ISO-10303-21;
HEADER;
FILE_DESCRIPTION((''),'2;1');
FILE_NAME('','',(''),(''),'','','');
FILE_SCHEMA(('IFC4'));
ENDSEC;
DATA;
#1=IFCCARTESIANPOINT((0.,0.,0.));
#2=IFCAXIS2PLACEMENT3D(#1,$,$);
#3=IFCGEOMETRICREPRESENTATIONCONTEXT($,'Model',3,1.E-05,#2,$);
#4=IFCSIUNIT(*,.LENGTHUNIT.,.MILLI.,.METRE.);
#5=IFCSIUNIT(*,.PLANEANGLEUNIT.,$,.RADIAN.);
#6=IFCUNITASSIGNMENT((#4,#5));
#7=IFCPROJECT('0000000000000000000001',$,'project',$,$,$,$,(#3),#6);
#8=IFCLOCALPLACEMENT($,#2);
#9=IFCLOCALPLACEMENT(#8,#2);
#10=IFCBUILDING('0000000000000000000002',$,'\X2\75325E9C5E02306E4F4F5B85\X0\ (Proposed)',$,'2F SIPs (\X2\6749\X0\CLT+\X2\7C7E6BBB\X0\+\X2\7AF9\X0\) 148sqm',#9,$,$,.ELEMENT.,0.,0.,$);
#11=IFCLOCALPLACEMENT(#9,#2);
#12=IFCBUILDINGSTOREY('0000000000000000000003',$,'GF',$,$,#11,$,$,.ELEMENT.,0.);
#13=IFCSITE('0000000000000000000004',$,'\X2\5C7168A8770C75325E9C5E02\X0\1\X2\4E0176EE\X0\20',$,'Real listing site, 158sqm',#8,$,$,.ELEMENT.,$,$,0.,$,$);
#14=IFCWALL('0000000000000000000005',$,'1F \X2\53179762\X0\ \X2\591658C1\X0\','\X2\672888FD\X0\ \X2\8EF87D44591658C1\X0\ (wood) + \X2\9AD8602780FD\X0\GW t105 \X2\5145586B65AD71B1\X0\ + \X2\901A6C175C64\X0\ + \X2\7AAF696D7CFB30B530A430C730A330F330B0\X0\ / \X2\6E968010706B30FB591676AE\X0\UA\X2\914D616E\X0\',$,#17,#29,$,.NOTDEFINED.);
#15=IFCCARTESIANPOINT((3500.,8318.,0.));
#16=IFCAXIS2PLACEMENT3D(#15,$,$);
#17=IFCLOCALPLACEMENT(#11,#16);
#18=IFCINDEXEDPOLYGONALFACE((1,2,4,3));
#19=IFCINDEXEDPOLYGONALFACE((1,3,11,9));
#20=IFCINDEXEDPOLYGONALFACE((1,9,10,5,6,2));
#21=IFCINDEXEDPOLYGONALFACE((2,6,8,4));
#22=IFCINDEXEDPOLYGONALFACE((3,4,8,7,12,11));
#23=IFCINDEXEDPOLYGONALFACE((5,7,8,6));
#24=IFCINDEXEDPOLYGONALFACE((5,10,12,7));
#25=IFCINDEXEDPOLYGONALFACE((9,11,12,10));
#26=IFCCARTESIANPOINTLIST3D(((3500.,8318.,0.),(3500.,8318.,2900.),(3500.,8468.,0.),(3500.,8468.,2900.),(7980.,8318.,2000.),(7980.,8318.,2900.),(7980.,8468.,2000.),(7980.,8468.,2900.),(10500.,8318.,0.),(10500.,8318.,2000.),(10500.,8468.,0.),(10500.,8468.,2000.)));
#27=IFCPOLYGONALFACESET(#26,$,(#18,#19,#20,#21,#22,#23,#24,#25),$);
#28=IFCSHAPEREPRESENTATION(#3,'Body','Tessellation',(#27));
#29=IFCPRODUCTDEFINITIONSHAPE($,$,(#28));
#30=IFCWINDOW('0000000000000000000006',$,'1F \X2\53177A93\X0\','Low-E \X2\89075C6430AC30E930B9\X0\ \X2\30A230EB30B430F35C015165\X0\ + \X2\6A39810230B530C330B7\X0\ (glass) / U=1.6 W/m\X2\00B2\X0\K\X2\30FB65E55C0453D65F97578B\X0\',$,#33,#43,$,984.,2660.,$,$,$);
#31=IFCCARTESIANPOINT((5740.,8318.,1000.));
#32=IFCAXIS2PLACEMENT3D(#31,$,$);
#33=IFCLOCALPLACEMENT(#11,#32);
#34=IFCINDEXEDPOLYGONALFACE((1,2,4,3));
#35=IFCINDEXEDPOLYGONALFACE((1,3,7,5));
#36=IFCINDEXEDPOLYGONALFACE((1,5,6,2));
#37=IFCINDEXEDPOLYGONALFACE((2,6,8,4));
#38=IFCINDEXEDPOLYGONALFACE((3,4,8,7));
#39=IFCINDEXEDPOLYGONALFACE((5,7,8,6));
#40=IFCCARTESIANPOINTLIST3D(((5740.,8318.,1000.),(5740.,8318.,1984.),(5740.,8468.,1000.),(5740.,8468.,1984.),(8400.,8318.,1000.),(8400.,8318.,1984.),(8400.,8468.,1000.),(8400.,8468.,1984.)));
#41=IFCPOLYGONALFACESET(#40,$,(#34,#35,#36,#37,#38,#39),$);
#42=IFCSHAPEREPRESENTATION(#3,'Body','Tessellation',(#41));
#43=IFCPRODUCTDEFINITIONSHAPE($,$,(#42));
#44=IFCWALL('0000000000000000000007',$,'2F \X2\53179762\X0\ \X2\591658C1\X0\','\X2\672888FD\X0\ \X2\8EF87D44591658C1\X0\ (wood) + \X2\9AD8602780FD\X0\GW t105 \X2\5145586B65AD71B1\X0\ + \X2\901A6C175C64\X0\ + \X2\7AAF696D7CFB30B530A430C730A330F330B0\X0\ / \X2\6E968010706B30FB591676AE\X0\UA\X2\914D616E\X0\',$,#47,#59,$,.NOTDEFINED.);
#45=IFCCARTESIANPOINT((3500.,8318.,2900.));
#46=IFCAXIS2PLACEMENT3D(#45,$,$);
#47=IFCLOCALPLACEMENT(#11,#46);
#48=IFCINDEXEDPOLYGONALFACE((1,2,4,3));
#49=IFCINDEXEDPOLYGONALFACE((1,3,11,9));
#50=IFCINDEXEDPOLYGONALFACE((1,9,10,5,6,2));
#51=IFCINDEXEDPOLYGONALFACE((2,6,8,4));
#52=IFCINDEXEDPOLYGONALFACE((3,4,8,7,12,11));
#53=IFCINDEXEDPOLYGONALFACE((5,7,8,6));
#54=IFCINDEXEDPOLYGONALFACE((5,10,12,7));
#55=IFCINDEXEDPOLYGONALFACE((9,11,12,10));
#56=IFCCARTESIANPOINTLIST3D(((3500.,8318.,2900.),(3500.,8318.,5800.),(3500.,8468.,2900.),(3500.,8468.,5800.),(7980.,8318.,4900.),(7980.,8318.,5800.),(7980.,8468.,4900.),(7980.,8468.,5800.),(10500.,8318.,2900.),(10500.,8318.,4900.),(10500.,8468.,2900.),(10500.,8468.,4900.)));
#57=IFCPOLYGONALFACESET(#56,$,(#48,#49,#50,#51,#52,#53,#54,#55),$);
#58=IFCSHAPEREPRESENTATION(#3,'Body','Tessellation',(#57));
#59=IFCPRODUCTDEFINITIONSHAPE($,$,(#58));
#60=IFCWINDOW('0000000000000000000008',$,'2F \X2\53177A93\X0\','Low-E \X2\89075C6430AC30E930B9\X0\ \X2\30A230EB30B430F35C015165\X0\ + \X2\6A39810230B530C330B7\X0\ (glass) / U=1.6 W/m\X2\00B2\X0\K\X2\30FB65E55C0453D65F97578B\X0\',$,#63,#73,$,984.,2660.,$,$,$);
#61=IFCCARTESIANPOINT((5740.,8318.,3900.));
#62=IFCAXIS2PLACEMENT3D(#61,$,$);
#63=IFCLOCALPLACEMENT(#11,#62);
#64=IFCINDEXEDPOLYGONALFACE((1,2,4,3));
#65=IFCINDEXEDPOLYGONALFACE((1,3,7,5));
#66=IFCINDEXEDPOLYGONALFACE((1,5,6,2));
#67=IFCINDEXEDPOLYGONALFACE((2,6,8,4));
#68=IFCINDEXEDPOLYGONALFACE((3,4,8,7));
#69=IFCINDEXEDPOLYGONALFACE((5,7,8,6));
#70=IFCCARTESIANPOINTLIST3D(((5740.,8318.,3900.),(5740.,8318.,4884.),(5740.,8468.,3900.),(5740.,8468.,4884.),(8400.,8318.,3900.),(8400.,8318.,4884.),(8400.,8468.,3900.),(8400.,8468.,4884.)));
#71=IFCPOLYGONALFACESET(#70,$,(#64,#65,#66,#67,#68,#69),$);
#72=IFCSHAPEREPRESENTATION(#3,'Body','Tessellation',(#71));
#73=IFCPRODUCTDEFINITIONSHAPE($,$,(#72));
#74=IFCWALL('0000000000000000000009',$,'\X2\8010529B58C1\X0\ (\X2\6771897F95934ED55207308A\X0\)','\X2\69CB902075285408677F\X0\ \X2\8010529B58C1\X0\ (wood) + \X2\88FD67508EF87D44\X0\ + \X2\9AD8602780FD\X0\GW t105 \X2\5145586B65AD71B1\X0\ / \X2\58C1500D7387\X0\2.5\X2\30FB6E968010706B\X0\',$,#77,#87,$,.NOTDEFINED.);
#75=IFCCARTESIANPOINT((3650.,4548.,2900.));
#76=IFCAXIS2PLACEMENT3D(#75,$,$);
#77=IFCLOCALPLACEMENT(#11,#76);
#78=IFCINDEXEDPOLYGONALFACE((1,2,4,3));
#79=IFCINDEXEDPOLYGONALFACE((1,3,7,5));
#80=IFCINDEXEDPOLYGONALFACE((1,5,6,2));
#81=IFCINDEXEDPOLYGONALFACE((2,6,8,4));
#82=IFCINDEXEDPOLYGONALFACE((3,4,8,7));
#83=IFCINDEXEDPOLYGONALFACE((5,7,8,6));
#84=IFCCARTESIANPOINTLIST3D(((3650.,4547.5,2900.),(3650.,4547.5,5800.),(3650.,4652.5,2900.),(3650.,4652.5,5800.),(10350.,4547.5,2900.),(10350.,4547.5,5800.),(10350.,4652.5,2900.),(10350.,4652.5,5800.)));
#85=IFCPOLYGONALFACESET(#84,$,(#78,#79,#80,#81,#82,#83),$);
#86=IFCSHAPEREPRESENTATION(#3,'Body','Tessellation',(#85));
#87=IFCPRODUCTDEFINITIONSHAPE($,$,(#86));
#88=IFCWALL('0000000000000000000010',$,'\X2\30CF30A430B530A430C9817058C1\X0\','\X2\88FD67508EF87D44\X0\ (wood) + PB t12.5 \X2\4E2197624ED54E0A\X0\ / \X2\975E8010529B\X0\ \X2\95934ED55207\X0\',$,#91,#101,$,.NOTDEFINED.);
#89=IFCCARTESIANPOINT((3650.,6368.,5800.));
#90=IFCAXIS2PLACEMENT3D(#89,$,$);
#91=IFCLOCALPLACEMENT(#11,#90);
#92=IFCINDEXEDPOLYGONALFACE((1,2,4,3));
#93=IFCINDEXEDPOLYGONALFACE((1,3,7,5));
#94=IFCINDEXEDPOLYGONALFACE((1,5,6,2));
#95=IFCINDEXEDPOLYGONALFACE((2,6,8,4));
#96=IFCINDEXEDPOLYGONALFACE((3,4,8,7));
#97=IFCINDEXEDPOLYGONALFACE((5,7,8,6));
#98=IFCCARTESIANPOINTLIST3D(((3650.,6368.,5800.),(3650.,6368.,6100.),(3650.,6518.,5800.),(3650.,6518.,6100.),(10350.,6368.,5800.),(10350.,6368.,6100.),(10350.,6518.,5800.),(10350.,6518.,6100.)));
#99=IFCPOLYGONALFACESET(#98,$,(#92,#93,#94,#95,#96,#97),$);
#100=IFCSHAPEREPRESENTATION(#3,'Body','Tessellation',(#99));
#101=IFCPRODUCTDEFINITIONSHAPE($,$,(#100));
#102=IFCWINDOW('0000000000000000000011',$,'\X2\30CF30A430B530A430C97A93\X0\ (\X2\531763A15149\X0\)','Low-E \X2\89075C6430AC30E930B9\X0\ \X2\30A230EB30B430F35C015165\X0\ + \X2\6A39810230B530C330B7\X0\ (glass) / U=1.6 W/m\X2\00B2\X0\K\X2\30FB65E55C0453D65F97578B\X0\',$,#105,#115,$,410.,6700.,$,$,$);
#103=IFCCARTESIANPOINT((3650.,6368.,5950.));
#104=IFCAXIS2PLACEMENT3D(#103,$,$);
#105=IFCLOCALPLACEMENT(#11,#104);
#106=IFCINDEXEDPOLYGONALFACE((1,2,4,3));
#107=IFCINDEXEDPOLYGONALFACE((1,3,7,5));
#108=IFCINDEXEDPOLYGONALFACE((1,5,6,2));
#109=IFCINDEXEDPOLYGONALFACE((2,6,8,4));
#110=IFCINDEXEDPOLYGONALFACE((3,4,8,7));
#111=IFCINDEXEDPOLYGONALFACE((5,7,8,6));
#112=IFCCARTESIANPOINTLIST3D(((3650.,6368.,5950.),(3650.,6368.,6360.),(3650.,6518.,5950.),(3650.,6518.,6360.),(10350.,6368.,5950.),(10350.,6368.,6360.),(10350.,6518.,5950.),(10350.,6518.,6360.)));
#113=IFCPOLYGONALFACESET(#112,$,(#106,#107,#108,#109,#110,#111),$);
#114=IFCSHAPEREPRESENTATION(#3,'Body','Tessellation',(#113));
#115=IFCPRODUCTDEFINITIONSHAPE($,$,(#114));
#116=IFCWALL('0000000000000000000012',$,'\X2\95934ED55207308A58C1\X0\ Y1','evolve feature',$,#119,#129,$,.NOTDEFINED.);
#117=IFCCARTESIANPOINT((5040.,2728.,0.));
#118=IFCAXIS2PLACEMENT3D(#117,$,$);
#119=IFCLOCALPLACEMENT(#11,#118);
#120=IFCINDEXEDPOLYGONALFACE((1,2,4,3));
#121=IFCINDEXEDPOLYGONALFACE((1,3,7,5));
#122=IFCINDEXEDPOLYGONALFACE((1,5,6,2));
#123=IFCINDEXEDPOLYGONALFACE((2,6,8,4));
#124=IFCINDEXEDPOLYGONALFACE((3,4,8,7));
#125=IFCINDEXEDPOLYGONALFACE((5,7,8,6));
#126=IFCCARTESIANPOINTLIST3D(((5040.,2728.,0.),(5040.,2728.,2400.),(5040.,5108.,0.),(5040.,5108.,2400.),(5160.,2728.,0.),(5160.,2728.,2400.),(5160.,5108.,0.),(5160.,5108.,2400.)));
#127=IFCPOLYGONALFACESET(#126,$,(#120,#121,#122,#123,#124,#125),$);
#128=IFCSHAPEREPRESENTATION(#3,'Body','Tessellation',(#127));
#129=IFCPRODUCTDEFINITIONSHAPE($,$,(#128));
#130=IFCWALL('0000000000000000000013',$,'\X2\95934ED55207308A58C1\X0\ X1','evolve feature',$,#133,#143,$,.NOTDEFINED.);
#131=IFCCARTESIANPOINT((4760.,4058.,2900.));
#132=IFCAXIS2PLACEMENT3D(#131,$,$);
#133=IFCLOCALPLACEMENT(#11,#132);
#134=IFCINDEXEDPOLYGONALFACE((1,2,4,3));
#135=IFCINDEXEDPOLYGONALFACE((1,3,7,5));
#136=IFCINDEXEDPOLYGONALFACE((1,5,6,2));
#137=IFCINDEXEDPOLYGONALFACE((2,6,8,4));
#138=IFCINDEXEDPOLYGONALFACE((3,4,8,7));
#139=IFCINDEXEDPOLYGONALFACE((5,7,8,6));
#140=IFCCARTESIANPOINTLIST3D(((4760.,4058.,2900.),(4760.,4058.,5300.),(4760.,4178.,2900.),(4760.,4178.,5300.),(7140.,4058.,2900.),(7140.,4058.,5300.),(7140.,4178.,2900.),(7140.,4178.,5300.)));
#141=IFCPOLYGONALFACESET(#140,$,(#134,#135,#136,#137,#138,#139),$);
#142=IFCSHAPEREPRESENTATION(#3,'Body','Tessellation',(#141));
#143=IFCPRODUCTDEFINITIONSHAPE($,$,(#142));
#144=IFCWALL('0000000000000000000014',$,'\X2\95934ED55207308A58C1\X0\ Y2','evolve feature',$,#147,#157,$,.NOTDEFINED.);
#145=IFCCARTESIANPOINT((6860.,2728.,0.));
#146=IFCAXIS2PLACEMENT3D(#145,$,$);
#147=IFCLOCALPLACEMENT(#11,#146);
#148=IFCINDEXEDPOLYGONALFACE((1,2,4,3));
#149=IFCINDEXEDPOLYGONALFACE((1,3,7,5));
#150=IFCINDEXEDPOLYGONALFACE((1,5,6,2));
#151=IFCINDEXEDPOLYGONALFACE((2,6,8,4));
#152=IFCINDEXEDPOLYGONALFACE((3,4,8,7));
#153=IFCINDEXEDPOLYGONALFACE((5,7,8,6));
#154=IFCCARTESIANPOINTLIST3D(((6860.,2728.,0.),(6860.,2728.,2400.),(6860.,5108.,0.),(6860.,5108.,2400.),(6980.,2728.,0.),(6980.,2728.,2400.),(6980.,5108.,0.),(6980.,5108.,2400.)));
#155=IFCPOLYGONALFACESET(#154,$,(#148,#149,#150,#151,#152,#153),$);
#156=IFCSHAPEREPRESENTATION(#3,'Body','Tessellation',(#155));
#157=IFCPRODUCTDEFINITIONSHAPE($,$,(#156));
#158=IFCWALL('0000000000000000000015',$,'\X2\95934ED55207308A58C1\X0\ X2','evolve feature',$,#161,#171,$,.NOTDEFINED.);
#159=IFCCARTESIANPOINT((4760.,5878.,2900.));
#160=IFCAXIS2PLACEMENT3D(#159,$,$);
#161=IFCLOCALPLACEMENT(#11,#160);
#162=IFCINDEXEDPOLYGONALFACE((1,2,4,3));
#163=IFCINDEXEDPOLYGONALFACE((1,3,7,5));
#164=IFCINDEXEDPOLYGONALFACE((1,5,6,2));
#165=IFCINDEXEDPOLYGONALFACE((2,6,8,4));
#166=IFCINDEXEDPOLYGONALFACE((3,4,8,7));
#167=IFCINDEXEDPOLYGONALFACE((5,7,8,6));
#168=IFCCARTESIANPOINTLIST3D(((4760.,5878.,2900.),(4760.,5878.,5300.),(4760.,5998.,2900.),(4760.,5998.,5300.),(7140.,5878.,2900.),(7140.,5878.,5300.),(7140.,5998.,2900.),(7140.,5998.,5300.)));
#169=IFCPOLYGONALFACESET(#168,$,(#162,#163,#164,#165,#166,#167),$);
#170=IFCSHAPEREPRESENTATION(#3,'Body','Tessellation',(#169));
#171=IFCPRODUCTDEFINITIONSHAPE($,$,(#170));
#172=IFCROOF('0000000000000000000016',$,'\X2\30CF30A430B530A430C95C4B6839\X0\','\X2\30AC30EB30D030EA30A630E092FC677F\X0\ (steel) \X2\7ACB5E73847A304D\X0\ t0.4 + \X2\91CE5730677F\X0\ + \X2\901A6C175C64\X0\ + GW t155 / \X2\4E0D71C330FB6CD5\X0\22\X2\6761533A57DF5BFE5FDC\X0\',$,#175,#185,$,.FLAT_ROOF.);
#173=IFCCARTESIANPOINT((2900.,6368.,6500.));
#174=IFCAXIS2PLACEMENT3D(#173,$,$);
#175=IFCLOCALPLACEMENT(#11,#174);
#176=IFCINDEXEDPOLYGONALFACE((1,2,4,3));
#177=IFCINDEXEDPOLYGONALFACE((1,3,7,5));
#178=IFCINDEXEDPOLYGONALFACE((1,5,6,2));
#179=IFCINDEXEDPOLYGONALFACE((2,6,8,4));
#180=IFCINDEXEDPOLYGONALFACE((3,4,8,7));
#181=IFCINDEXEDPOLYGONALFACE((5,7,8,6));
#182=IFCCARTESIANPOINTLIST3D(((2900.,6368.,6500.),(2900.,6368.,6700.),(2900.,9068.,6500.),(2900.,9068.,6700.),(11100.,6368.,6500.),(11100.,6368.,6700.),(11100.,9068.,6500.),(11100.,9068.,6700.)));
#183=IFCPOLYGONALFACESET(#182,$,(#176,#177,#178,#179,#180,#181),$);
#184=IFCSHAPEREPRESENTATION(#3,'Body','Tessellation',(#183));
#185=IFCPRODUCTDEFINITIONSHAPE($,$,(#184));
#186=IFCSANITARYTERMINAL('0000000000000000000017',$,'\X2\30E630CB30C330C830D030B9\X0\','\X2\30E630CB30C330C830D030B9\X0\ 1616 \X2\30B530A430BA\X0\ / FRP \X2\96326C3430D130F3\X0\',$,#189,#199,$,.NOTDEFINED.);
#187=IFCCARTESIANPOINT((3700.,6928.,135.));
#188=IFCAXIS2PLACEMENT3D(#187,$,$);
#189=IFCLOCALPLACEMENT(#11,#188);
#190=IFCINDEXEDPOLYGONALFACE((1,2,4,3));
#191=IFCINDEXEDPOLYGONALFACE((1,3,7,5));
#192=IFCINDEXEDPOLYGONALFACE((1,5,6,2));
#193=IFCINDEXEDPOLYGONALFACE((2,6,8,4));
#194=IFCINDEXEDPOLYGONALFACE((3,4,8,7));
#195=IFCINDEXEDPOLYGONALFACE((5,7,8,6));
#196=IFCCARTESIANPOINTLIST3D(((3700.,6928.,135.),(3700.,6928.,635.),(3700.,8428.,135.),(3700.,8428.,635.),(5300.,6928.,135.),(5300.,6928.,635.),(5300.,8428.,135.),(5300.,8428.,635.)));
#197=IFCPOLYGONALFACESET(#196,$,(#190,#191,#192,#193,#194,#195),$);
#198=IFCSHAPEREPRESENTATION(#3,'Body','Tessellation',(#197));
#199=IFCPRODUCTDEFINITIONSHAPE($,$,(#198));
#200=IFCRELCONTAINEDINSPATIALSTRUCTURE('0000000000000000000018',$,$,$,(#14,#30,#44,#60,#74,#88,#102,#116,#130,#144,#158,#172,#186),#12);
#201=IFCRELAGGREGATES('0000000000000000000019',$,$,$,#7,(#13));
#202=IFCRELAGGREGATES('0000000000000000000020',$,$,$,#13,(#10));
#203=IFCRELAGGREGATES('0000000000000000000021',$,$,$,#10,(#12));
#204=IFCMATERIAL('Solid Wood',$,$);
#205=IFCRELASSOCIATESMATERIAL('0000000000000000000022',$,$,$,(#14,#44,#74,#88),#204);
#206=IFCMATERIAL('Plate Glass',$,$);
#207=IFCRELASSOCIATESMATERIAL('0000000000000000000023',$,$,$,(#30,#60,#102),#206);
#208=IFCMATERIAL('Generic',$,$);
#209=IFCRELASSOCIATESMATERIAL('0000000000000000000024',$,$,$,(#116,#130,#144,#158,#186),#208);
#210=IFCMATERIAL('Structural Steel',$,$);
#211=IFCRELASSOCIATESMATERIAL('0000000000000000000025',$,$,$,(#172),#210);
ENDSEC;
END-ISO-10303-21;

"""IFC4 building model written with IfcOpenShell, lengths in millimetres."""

from ifc_helpers import new_model, si_unit, frame, frame_2d, origin, place, context, project, spatial, rectangle, extrude, material, element, fill, save


model = new_model("IFC4")

# Units and contexts
model_context = context("Model", 3, precision=1e-05, world=origin())
ifc_project = project(units=[si_unit("LENGTHUNIT", "METRE", prefix="MILLI"), si_unit("PLANEANGLEUNIT", "RADIAN")], contexts=[model_context])

# Site, building, storey
site_placement = place(None, origin())
site = spatial("IfcSite", under=ifc_project, at=site_placement, Name="山梨県甲府市1丁目20", ObjectType="Real listing site, 158sqm", CompositionType="ELEMENT", RefElevation=0.0)
building_placement = place(site_placement, origin())
building = spatial("IfcBuilding", under=site, at=building_placement, Name="甲府市の住宅 (Proposed)", ObjectType="2F SIPs (杉CLT+籾殻+竹) 148sqm", CompositionType="ELEMENT", ElevationOfRefHeight=0.0, ElevationOfTerrain=0.0)
storey_placement = place(building_placement, origin())
storey = spatial("IfcBuildingStorey", under=building, at=storey_placement, Name="GF", CompositionType="ELEMENT", Elevation=0.0)

# Wall, opening, window
ifc_material_1 = material(Name="Solid Wood")
wall_1_placement = place(storey_placement, frame((3500.0, 8318.0, 0.0)))
wall_1 = element("IfcWall", 1, at=wall_1_placement, inside=storey, material=ifc_material_1, Name="1F 北面 外壁", Description="木製 軸組外壁 (wood) + 高性能GW t105 充填断熱 + 通気層 + 窯業系サイディング / 準耐火・外皮UA配慮", PredefinedType="NOTDEFINED", context=model_context, shape_type="SweptSolid", body=[
    extrude(rectangle(XDim=7000.0, YDim=150.0, at=frame_2d((3500.0, 75.0))), frame((3500.0, 8318.0, 0.0)), (0.0, 0.0, 1.0), 2900.0),
])
opening_1_placement = place(storey_placement, frame((5740.0, 8318.0, 1000.0)))
opening_1 = element("IfcOpeningElement", 2, at=opening_1_placement, cuts=wall_1, PredefinedType="NOTDEFINED", context=model_context, shape_type="SweptSolid", body=[
    extrude(rectangle(XDim=2660.0, YDim=150.0, at=frame_2d((1330.0, 75.0))), frame((5740.0, 8318.0, 1000.0)), (0.0, 0.0, 1.0), 984.0),
])
ifc_material_2 = material(Name="Plate Glass")
window_1_placement = place(storey_placement, frame((5740.0, 8318.0, 1000.0)))
window_1 = element("IfcWindow", 3, at=window_1_placement, inside=storey, material=ifc_material_2, Name="1F 北窓", Description="Low-E 複層ガラス アルゴン封入 + 樹脂サッシ (glass) / U=1.6 W/m²K・日射取得型", OverallHeight=984.0, OverallWidth=2660.0, context=model_context, shape_type="SweptSolid", body=[
    extrude(rectangle(XDim=2660.0, YDim=150.0, at=frame_2d((1330.0, 75.0))), frame((5740.0, 8318.0, 1000.0)), (0.0, 0.0, 1.0), 984.0),
])
fill(opening_1, window_1)

# Wall, opening, window
wall_2_placement = place(storey_placement, frame((3500.0, 8318.0, 2900.0)))
wall_2 = element("IfcWall", 4, at=wall_2_placement, inside=storey, material=ifc_material_1, Name="2F 北面 外壁", Description="木製 軸組外壁 (wood) + 高性能GW t105 充填断熱 + 通気層 + 窯業系サイディング / 準耐火・外皮UA配慮", PredefinedType="NOTDEFINED", context=model_context, shape_type="SweptSolid", body=[
    extrude(rectangle(XDim=7000.0, YDim=150.0, at=frame_2d((3500.0, 75.0))), frame((3500.0, 8318.0, 2900.0)), (0.0, 0.0, 1.0), 2900.0),
])
opening_2_placement = place(storey_placement, frame((5740.0, 8318.0, 3900.0)))
opening_2 = element("IfcOpeningElement", 5, at=opening_2_placement, cuts=wall_2, PredefinedType="NOTDEFINED", context=model_context, shape_type="SweptSolid", body=[
    extrude(rectangle(XDim=2660.0, YDim=150.0, at=frame_2d((1330.0, 75.0))), frame((5740.0, 8318.0, 3900.0)), (0.0, 0.0, 1.0), 984.0),
])
window_2_placement = place(storey_placement, frame((5740.0, 8318.0, 3900.0)))
window_2 = element("IfcWindow", 6, at=window_2_placement, inside=storey, material=ifc_material_2, Name="2F 北窓", Description="Low-E 複層ガラス アルゴン封入 + 樹脂サッシ (glass) / U=1.6 W/m²K・日射取得型", OverallHeight=984.0, OverallWidth=2660.0, context=model_context, shape_type="SweptSolid", body=[
    extrude(rectangle(XDim=2660.0, YDim=150.0, at=frame_2d((1330.0, 75.0))), frame((5740.0, 8318.0, 3900.0)), (0.0, 0.0, 1.0), 984.0),
])
fill(opening_2, window_2)

# Wall
wall_3_placement = place(storey_placement, frame((3650.0, 4548.0, 2900.0)))
element("IfcWall", 7, at=wall_3_placement, inside=storey, material=ifc_material_1, Name="耐力壁 (東西間仕切り)", Description="構造用合板 耐力壁 (wood) + 製材軸組 + 高性能GW t105 充填断熱 / 壁倍率2.5・準耐火", PredefinedType="NOTDEFINED", context=model_context, shape_type="SweptSolid", body=[
    extrude(rectangle(XDim=6700.0, YDim=105.0, at=frame_2d((3350.0, 52.0))), frame((3650.0, 4548.0, 2900.0)), (0.0, 0.0, 1.0), 2900.0),
])

# Wall, opening, window
wall_4_placement = place(storey_placement, frame((3650.0, 6368.0, 5800.0)))
wall_4 = element("IfcWall", 8, at=wall_4_placement, inside=storey, material=ifc_material_1, Name="ハイサイド腰壁", Description="製材軸組 (wood) + PB t12.5 両面仕上 / 非耐力 間仕切", PredefinedType="NOTDEFINED", context=model_context, shape_type="SweptSolid", body=[
    extrude(rectangle(XDim=6700.0, YDim=150.0, at=frame_2d((3350.0, 75.0))), frame((3650.0, 6368.0, 5800.0)), (0.0, 0.0, 1.0), 700.0),
])
opening_3_placement = place(storey_placement, frame((3650.0, 6368.0, 5950.0)))
opening_3 = element("IfcOpeningElement", 9, at=opening_3_placement, cuts=wall_4, PredefinedType="NOTDEFINED", context=model_context, shape_type="SweptSolid", body=[
    extrude(rectangle(XDim=6700.0, YDim=150.0, at=frame_2d((3350.0, 75.0))), frame((3650.0, 6368.0, 5950.0)), (0.0, 0.0, 1.0), 410.0),
])
window_3_placement = place(storey_placement, frame((3650.0, 6368.0, 5950.0)))
window_3 = element("IfcWindow", 10, at=window_3_placement, inside=storey, material=ifc_material_2, Name="ハイサイド窓 (北採光)", Description="Low-E 複層ガラス アルゴン封入 + 樹脂サッシ (glass) / U=1.6 W/m²K・日射取得型", OverallHeight=410.0, OverallWidth=6700.0, context=model_context, shape_type="SweptSolid", body=[
    extrude(rectangle(XDim=6700.0, YDim=150.0, at=frame_2d((3350.0, 75.0))), frame((3650.0, 6368.0, 5950.0)), (0.0, 0.0, 1.0), 410.0),
])
fill(opening_3, window_3)

# Walls
ifc_material_3 = material(Name="Generic")
wall_5_placement = place(storey_placement, frame((5040.0, 2728.0, 0.0)))
element("IfcWall", 11, at=wall_5_placement, inside=storey, material=ifc_material_3, Name="間仕切り壁 Y1", Description="evolve feature", PredefinedType="NOTDEFINED", context=model_context, shape_type="SweptSolid", body=[
    extrude(rectangle(XDim=120.0, YDim=2380.0, at=frame_2d((60.0, 1190.0))), frame((5040.0, 2728.0, 0.0)), (0.0, 0.0, 1.0), 2400.0),
])
wall_6_placement = place(storey_placement, frame((4760.0, 4058.0, 2900.0)))
element("IfcWall", 12, at=wall_6_placement, inside=storey, material=ifc_material_3, Name="間仕切り壁 X1", Description="evolve feature", PredefinedType="NOTDEFINED", context=model_context, shape_type="SweptSolid", body=[
    extrude(rectangle(XDim=2380.0, YDim=120.0, at=frame_2d((1190.0, 60.0))), frame((4760.0, 4058.0, 2900.0)), (0.0, 0.0, 1.0), 2400.0),
])
wall_7_placement = place(storey_placement, frame((6860.0, 2728.0, 0.0)))
element("IfcWall", 13, at=wall_7_placement, inside=storey, material=ifc_material_3, Name="間仕切り壁 Y2", Description="evolve feature", PredefinedType="NOTDEFINED", context=model_context, shape_type="SweptSolid", body=[
    extrude(rectangle(XDim=120.0, YDim=2380.0, at=frame_2d((60.0, 1190.0))), frame((6860.0, 2728.0, 0.0)), (0.0, 0.0, 1.0), 2400.0),
])
wall_8_placement = place(storey_placement, frame((4760.0, 5878.0, 2900.0)))
element("IfcWall", 14, at=wall_8_placement, inside=storey, material=ifc_material_3, Name="間仕切り壁 X2", Description="evolve feature", PredefinedType="NOTDEFINED", context=model_context, shape_type="SweptSolid", body=[
    extrude(rectangle(XDim=2380.0, YDim=120.0, at=frame_2d((1190.0, 60.0))), frame((4760.0, 5878.0, 2900.0)), (0.0, 0.0, 1.0), 2400.0),
])

# Roof
ifc_material_4 = material(Name="Structural Steel")
roof_placement = place(storey_placement, frame((2900.0, 6368.0, 6500.0)))
element("IfcRoof", 15, at=roof_placement, inside=storey, material=ifc_material_4, Name="ハイサイド屋根", Description="ガルバリウム鋼板 (steel) 立平葺き t0.4 + 野地板 + 通気層 + GW t155 / 不燃・法22条区域対応", PredefinedType="FLAT_ROOF", context=model_context, shape_type="SweptSolid", body=[
    extrude(rectangle(XDim=8200.0, YDim=2700.0, at=frame_2d((4100.0, 1350.0))), frame((2900.0, 6368.0, 6500.0)), (0.0, 0.0, 1.0), 200.0),
])

# Sanitary terminal
sanitary_terminal_1_placement = place(storey_placement, frame((3700.0, 6928.0, 135.0)))
element("IfcSanitaryTerminal", 16, at=sanitary_terminal_1_placement, inside=storey, material=ifc_material_3, Name="ユニットバス", Description="ユニットバス 1616 サイズ / FRP 防水パン", PredefinedType="NOTDEFINED", context=model_context, shape_type="SweptSolid", body=[
    extrude(rectangle(XDim=1600.0, YDim=1500.0, at=frame_2d((800.0, 750.0))), frame((3700.0, 6928.0, 135.0)), (0.0, 0.0, 1.0), 500.0),
])

save(model, "model.ifc")
